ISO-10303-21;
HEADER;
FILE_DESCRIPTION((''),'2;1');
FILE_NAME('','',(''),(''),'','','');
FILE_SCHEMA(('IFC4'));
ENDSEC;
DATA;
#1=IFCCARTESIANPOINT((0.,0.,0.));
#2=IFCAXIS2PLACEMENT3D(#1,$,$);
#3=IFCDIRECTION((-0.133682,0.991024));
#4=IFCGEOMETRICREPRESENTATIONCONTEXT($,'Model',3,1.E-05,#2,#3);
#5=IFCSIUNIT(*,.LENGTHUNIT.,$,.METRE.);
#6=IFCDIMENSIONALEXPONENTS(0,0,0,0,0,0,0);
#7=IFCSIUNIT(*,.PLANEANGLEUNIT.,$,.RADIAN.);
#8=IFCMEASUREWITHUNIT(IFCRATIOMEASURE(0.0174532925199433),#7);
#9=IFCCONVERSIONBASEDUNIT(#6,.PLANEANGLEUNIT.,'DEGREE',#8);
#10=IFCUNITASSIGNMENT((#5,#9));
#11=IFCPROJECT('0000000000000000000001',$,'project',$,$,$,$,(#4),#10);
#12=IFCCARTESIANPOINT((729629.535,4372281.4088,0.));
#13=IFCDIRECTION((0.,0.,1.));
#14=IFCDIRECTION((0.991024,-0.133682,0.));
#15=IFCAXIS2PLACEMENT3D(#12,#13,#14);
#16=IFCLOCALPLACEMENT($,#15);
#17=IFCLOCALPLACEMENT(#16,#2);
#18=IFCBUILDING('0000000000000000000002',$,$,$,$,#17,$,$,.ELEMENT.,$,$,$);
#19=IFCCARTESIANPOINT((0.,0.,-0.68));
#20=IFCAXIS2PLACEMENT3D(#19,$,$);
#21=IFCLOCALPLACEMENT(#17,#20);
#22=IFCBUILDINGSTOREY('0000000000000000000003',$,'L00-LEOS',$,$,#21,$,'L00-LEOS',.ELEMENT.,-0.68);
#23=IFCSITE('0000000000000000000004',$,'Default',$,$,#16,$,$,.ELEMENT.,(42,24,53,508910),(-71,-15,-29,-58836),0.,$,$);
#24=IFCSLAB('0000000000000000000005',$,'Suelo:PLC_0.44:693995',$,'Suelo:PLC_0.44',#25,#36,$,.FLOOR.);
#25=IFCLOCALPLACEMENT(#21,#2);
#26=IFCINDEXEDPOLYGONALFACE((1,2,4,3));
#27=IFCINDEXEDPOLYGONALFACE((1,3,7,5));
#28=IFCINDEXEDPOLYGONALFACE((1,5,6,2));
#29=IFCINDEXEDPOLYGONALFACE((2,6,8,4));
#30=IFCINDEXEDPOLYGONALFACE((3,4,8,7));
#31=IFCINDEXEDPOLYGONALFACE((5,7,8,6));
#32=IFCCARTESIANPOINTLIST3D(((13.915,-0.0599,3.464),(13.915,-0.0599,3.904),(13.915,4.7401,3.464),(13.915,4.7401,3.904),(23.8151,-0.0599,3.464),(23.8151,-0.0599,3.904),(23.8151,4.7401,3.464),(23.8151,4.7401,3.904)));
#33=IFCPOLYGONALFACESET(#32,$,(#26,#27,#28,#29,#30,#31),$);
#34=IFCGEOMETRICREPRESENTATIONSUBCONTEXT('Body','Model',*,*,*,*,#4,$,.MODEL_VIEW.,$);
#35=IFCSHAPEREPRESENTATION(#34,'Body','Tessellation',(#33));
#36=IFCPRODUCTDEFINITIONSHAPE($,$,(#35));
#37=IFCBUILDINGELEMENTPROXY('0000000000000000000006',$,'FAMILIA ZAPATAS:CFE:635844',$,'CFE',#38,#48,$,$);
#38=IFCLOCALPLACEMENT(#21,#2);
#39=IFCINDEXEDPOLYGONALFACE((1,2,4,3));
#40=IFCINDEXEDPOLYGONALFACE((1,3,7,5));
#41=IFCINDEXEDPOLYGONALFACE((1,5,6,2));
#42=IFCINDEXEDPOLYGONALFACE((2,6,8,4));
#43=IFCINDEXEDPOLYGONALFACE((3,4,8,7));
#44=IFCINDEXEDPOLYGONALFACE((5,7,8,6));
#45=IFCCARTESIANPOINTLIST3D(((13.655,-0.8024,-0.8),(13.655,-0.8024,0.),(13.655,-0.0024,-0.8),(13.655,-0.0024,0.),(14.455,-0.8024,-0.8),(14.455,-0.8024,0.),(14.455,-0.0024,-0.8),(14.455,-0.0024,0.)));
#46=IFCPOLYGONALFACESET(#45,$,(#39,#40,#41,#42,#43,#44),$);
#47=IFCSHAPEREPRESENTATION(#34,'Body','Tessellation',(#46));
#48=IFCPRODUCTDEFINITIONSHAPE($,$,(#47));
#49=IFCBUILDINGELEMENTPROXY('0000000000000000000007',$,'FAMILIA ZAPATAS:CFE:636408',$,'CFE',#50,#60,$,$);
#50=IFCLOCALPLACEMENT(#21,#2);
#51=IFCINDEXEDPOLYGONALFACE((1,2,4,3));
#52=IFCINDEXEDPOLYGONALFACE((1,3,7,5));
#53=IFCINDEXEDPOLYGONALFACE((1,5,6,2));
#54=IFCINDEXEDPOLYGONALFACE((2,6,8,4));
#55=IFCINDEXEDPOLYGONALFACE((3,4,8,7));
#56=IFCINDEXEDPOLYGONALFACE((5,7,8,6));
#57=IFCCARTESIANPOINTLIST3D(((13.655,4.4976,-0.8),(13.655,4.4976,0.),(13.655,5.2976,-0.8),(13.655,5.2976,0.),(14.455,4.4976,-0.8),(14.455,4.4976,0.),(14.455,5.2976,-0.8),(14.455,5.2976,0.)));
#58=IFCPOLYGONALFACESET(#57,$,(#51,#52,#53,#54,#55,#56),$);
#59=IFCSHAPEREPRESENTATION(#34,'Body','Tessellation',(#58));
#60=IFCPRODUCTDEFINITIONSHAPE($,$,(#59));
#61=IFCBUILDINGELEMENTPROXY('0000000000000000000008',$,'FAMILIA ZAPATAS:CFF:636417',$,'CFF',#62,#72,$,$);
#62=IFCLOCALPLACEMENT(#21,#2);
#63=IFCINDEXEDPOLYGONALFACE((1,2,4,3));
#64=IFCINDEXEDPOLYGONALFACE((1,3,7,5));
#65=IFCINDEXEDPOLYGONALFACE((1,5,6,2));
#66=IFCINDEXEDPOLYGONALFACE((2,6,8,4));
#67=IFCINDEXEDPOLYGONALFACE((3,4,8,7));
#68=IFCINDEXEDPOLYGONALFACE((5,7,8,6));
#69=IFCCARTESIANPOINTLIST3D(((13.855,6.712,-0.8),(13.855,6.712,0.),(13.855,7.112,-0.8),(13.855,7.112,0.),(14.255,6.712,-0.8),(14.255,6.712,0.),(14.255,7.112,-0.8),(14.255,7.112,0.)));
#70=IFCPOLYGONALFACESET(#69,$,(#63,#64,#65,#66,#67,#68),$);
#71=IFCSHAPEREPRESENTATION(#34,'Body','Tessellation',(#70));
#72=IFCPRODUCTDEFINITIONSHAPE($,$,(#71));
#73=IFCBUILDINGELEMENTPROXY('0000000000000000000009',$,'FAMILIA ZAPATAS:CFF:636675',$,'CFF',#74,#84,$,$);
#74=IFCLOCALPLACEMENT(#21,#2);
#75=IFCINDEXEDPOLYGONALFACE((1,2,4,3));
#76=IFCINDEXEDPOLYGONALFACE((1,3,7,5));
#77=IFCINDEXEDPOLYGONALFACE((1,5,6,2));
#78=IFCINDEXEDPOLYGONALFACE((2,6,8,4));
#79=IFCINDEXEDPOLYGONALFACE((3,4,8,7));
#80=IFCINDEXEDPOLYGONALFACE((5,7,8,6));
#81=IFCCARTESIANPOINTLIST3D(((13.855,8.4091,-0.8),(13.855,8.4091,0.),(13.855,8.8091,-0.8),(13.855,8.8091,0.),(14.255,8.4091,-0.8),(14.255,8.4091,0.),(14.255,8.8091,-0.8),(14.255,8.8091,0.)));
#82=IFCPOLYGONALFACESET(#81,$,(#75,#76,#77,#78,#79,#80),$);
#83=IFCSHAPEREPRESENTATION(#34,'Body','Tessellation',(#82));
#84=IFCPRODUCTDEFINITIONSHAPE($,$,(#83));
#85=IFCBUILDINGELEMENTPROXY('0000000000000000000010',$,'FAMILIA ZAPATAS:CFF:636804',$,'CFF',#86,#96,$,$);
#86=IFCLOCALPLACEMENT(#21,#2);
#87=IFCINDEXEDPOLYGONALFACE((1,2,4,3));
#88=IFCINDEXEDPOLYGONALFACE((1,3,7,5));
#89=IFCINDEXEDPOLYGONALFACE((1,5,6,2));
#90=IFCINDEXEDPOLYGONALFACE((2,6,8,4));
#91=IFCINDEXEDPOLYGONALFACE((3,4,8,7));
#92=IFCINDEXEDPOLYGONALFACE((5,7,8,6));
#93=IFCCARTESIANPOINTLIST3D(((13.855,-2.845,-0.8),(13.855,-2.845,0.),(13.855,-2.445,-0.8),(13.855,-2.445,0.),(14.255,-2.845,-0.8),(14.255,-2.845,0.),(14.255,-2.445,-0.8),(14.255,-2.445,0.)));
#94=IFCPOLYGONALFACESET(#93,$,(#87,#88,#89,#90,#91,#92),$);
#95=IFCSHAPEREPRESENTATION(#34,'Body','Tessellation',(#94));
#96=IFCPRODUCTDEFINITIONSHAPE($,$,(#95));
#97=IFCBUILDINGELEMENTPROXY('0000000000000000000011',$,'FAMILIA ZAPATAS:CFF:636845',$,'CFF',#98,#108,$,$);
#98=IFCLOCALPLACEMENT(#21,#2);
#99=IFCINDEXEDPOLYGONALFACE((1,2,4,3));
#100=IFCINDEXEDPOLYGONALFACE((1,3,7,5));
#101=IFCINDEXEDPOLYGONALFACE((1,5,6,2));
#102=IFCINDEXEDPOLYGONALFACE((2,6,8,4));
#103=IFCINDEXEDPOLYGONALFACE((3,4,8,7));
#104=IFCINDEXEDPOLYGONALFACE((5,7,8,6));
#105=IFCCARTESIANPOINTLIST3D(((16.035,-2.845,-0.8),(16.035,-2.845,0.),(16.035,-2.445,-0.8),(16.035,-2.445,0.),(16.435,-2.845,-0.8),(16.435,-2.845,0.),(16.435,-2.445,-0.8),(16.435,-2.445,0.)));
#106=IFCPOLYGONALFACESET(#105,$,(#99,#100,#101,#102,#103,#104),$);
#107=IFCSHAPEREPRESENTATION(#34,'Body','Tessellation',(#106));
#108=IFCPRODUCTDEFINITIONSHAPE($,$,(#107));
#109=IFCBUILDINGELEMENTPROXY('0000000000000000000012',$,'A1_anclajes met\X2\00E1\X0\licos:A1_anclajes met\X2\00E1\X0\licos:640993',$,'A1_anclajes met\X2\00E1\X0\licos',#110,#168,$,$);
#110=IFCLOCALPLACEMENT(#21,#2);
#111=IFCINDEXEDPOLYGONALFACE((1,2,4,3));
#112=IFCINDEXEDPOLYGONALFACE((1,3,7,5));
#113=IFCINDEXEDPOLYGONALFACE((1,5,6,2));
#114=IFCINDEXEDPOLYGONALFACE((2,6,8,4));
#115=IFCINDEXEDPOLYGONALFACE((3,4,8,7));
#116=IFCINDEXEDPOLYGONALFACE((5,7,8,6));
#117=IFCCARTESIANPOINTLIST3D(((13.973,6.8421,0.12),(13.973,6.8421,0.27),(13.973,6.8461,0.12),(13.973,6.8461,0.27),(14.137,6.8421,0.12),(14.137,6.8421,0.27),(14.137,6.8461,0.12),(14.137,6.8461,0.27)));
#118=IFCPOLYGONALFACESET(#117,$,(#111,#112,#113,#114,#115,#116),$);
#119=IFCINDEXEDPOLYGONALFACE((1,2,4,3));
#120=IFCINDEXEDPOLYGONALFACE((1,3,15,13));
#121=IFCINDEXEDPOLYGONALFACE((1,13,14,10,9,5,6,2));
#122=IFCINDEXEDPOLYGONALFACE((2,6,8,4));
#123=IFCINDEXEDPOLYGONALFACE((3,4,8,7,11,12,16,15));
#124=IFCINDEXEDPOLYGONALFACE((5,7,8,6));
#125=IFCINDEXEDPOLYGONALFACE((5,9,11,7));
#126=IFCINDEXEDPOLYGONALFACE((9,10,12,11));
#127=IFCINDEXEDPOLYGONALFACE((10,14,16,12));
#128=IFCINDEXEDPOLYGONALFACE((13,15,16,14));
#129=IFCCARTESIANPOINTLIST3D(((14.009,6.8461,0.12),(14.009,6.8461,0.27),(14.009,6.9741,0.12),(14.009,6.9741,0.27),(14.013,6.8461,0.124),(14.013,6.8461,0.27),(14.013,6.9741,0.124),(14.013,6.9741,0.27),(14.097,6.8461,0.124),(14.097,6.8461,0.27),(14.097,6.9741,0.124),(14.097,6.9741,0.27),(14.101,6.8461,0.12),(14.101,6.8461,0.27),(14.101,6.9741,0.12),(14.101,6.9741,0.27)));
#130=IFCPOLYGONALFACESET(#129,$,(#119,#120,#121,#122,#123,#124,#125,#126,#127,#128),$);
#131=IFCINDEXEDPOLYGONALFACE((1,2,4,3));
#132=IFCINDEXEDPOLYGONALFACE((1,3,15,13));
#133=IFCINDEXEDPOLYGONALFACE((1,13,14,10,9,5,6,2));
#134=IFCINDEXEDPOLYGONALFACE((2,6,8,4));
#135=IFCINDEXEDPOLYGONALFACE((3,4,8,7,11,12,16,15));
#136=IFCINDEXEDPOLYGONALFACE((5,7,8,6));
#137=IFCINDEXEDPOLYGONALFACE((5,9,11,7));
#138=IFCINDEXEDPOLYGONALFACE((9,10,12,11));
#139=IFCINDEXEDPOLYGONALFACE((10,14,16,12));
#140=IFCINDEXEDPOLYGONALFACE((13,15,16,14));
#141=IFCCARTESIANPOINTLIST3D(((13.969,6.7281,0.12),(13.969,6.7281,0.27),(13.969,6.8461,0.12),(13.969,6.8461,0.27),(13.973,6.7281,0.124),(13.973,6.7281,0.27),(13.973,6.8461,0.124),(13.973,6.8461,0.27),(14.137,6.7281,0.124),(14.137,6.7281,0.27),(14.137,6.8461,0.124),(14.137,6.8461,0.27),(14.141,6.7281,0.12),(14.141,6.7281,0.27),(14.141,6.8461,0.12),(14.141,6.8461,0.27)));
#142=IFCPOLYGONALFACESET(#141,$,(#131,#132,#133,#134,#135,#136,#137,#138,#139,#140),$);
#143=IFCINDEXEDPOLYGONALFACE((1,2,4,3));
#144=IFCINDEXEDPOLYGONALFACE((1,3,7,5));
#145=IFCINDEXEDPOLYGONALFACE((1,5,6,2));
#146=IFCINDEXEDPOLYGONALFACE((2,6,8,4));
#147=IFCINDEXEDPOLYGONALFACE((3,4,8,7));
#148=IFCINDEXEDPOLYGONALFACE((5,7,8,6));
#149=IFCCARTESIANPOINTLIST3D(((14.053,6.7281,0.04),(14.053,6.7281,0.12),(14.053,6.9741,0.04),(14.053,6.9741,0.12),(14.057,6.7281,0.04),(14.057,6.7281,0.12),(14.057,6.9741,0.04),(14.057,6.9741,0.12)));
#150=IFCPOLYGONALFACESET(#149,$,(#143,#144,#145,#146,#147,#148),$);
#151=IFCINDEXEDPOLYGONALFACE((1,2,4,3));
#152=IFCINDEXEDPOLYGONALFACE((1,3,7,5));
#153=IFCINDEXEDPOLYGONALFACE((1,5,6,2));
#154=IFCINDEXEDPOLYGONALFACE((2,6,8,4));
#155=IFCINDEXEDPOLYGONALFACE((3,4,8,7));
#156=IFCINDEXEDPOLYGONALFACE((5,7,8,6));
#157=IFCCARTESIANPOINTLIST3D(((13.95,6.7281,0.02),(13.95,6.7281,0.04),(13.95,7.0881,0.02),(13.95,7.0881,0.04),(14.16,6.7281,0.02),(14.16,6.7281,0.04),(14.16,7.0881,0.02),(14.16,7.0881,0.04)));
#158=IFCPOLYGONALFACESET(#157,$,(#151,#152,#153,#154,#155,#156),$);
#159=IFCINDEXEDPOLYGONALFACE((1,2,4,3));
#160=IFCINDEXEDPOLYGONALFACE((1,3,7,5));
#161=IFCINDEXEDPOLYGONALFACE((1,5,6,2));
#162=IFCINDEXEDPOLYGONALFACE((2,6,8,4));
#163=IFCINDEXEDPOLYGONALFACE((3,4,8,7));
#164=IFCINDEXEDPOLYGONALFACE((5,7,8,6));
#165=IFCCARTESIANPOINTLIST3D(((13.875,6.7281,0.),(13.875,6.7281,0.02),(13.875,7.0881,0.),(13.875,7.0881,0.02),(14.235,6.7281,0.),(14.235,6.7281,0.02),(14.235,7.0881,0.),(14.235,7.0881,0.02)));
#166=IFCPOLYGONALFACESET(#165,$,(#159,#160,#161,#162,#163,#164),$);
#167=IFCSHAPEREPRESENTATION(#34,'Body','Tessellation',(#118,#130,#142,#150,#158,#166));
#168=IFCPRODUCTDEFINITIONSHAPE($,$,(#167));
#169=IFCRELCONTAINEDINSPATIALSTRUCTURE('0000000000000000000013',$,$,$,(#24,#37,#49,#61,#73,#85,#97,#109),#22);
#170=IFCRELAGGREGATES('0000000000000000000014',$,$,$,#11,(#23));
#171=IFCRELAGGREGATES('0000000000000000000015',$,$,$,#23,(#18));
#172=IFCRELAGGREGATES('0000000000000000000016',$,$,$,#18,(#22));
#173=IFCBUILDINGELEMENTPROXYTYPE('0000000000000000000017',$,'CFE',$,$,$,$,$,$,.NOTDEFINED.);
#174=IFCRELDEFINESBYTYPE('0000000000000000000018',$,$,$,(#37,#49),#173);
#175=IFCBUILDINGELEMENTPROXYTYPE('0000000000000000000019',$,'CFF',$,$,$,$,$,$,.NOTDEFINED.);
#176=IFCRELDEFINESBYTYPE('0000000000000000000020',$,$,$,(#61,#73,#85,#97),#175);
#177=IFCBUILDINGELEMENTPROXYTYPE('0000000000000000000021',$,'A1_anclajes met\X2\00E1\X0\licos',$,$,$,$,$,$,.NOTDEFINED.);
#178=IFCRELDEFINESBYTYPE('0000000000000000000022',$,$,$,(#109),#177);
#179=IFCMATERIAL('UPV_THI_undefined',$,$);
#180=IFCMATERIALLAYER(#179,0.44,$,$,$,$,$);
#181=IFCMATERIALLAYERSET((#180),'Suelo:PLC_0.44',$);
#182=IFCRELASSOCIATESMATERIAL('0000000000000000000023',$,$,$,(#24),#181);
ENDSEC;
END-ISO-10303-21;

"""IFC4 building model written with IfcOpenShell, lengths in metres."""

from ifc_helpers import new_model, entity, si_unit, converted_unit, direction, frame, frame_2d, origin, origin_2d_with_axis, place, context, subcontext, project, spatial, polyline, rectangle, outline, extrude, source, transform, mapped, material, layer, layer_set, layer_usage, type_object, type_shapes, element, save


model = new_model("IFC4")

# Units and contexts
model_context = context("Model", 3, precision=1e-05, world=origin(), true_north=direction((-0.133682, 0.991024)))
body_context = subcontext(model_context, "Body", "Model", "MODEL_VIEW")
ifc_project = project(units=[si_unit("LENGTHUNIT", "METRE"), converted_unit("PLANEANGLEUNIT", "DEGREE", entity("IfcRatioMeasure", 0.0174532925199433), si_unit("PLANEANGLEUNIT", "RADIAN"), dimensions=[0, 0, 0, 0, 0, 0, 0])], contexts=[model_context])

# Site, building, storey
site_placement = place(None, frame((729629.535, 4372281.4088, 0.0), z_axis=(0.0, 0.0, 1.0), x_axis=(0.991024, -0.133682, 0.0)))
site = spatial("IfcSite", under=ifc_project, at=site_placement, Name="Default", CompositionType="ELEMENT", RefLatitude=(42, 24, 53, 508910), RefLongitude=(-71, -15, -29, -58836), RefElevation=0.0)
building_placement = place(site_placement, origin())
building = spatial("IfcBuilding", under=site, at=building_placement, CompositionType="ELEMENT")
storey_placement = place(building_placement, frame((0.0, 0.0, -0.68)))
storey = spatial("IfcBuildingStorey", under=building, at=storey_placement, Name="L00-LEOS", LongName="L00-LEOS", CompositionType="ELEMENT", Elevation=-0.68)

# Shared definitions
ifc_material_1 = material(Name="UPV_THI_undefined")

# Slab
ifc_layer_1 = layer(ifc_material_1, 0.44)
ifc_layer_set_1 = layer_set([ifc_layer_1], Name="Suelo:PLC_0.44")
ifc_layer_usage_1 = layer_usage(ifc_layer_set_1, "AXIS3", "POSITIVE", 0.0)
slab_1_placement = place(storey_placement, origin())
element("IfcSlab", 1, at=slab_1_placement, inside=storey, material=ifc_layer_usage_1, Name="Suelo:PLC_0.44:693995", ObjectType="Suelo:PLC_0.44", PredefinedType="FLOOR", context=body_context, shape_type="SweptSolid", body=[
    extrude(rectangle(XDim=4.8, YDim=9.9001, at=frame_2d((0.0, 0.0), x_axis=(1.0, 0.0))), frame((18.865, 2.3401, 3.904), z_axis=(0.0, 0.0, -1.0), x_axis=(0.0, 1.0, 0.0)), (0.0, 0.0, 1.0), 0.44),
])

# Building element proxies
building_element_proxy_type_1 = type_object("IfcBuildingElementProxyType", Name="CFE")
shared_shape_1 = source(origin(), body_context, "Body", "SweptSolid", [
    extrude(rectangle(XDim=0.8, YDim=0.8, at=origin_2d_with_axis()), frame((0.0, 0.0, 0.0), z_axis=(0.0, 0.0, 1.0), x_axis=(0.0, -1.0, 0.0)), (0.0, 0.0, 1.0), 0.8),
])
type_shapes(building_element_proxy_type_1, [shared_shape_1])
for number, where, name in (
    (2, (14.055, -0.4024, -0.8), "FAMILIA ZAPATAS:CFE:635844"),
    (3, (14.055, 4.8976, -0.8), "FAMILIA ZAPATAS:CFE:636408"),
):
    element("IfcBuildingElementProxy", number, at=place(storey_placement, frame(where)), inside=storey, type_object=building_element_proxy_type_1, Name=name, ObjectType="CFE", context=body_context, shape_type="MappedRepresentation", body=[
        mapped(shared_shape_1, transform((0.0, 0.0, 0.0), scale=1.0)),
    ])
building_element_proxy_type_2 = type_object("IfcBuildingElementProxyType", Name="CFF")
shared_shape_2 = source(origin(), body_context, "Body", "SweptSolid", [
    extrude(rectangle(XDim=0.4, YDim=0.4, at=origin_2d_with_axis()), frame((0.0, 0.0, 0.0), z_axis=(0.0, 0.0, 1.0), x_axis=(0.0, -1.0, 0.0)), (0.0, 0.0, 1.0), 0.8),
])
type_shapes(building_element_proxy_type_2, [shared_shape_2])
for number, where, name in (
    (4, (14.055, 6.912, -0.8), "FAMILIA ZAPATAS:CFF:636417"),
    (5, (14.055, 8.6091, -0.8), "FAMILIA ZAPATAS:CFF:636675"),
    (6, (14.055, -2.645, -0.8), "FAMILIA ZAPATAS:CFF:636804"),
    (7, (16.235, -2.645, -0.8), "FAMILIA ZAPATAS:CFF:636845"),
):
    element("IfcBuildingElementProxy", number, at=place(storey_placement, frame(where)), inside=storey, type_object=building_element_proxy_type_2, Name=name, ObjectType="CFF", context=body_context, shape_type="MappedRepresentation", body=[
        mapped(shared_shape_2, transform((0.0, 0.0, 0.0), scale=1.0)),
    ])
building_element_proxy_type_3 = type_object("IfcBuildingElementProxyType", Name="A1_anclajes metálicos")
shared_shape_3 = source(origin(), body_context, "Body", "SweptSolid", [
    extrude(rectangle(XDim=0.164, YDim=0.004, at=frame_2d((0.0, 0.0), x_axis=(1.0, 0.0))), frame((-0.064, 0.0, 0.12), z_axis=(0.0, 0.0, 1.0), x_axis=(0.0, -1.0, 0.0)), (0.0, 0.0, 1.0), 0.15),
    extrude(outline(polyline([(-0.076, -0.046), (0.074, -0.046), (0.074, -0.042), (-0.072, -0.042), (-0.072, 0.042), (0.074, 0.042), (0.074, 0.046), (-0.076, 0.046), (-0.076, -0.046)])), frame((-0.062, 0.0, 0.196), z_axis=(1.0, 0.0, 0.0), x_axis=(0.0, 0.0, 1.0)), (0.0, 0.0, 1.0), 0.128),
    extrude(outline(polyline([(-0.076, -0.086), (0.074, -0.086), (0.074, -0.082), (-0.072, -0.082), (-0.072, 0.082), (0.074, 0.082), (0.074, 0.086), (-0.076, 0.086), (-0.076, -0.086)])), frame((-0.18, 0.0, 0.196), z_axis=(1.0, 0.0, 0.0), x_axis=(0.0, 0.0, 1.0)), (0.0, 0.0, 1.0), 0.118),
    extrude(rectangle(XDim=0.004, YDim=0.246, at=origin_2d_with_axis()), frame((-0.057, 0.0, 0.04), z_axis=(0.0, 0.0, 1.0), x_axis=(0.0, -1.0, 0.0)), (0.0, 0.0, 1.0), 0.08),
    extrude(rectangle(XDim=0.36, YDim=0.21, at=frame_2d((0.0, 0.0), x_axis=(1.0, 0.0))), frame((0.0, 0.0, 0.02), z_axis=(0.0, 0.0, 1.0), x_axis=(-1.0, 0.0, 0.0)), (0.0, 0.0, 1.0), 0.02),
    extrude(rectangle(XDim=0.36, YDim=0.36, at=frame_2d((0.0, 0.0), x_axis=(1.0, 0.0))), frame((0.0, 0.0, 0.0), z_axis=(0.0, 0.0, 1.0), x_axis=(-1.0, 0.0, 0.0)), (0.0, 0.0, 1.0), 0.02),
])
type_shapes(building_element_proxy_type_3, [shared_shape_3])
proxy_1_placement = place(storey_placement, frame((14.055, 6.9081, 0.0), z_axis=(0.0, 0.0, 1.0), x_axis=(0.0, 1.0, 0.0)))
element("IfcBuildingElementProxy", 8, at=proxy_1_placement, inside=storey, type_object=building_element_proxy_type_3, Name="A1_anclajes metálicos:A1_anclajes metálicos:640993", ObjectType="A1_anclajes metálicos", context=body_context, shape_type="MappedRepresentation", body=[
    mapped(shared_shape_3, transform((0.0, 0.0, 0.0), scale=1.0)),
])

save(model, "model.ifc")
